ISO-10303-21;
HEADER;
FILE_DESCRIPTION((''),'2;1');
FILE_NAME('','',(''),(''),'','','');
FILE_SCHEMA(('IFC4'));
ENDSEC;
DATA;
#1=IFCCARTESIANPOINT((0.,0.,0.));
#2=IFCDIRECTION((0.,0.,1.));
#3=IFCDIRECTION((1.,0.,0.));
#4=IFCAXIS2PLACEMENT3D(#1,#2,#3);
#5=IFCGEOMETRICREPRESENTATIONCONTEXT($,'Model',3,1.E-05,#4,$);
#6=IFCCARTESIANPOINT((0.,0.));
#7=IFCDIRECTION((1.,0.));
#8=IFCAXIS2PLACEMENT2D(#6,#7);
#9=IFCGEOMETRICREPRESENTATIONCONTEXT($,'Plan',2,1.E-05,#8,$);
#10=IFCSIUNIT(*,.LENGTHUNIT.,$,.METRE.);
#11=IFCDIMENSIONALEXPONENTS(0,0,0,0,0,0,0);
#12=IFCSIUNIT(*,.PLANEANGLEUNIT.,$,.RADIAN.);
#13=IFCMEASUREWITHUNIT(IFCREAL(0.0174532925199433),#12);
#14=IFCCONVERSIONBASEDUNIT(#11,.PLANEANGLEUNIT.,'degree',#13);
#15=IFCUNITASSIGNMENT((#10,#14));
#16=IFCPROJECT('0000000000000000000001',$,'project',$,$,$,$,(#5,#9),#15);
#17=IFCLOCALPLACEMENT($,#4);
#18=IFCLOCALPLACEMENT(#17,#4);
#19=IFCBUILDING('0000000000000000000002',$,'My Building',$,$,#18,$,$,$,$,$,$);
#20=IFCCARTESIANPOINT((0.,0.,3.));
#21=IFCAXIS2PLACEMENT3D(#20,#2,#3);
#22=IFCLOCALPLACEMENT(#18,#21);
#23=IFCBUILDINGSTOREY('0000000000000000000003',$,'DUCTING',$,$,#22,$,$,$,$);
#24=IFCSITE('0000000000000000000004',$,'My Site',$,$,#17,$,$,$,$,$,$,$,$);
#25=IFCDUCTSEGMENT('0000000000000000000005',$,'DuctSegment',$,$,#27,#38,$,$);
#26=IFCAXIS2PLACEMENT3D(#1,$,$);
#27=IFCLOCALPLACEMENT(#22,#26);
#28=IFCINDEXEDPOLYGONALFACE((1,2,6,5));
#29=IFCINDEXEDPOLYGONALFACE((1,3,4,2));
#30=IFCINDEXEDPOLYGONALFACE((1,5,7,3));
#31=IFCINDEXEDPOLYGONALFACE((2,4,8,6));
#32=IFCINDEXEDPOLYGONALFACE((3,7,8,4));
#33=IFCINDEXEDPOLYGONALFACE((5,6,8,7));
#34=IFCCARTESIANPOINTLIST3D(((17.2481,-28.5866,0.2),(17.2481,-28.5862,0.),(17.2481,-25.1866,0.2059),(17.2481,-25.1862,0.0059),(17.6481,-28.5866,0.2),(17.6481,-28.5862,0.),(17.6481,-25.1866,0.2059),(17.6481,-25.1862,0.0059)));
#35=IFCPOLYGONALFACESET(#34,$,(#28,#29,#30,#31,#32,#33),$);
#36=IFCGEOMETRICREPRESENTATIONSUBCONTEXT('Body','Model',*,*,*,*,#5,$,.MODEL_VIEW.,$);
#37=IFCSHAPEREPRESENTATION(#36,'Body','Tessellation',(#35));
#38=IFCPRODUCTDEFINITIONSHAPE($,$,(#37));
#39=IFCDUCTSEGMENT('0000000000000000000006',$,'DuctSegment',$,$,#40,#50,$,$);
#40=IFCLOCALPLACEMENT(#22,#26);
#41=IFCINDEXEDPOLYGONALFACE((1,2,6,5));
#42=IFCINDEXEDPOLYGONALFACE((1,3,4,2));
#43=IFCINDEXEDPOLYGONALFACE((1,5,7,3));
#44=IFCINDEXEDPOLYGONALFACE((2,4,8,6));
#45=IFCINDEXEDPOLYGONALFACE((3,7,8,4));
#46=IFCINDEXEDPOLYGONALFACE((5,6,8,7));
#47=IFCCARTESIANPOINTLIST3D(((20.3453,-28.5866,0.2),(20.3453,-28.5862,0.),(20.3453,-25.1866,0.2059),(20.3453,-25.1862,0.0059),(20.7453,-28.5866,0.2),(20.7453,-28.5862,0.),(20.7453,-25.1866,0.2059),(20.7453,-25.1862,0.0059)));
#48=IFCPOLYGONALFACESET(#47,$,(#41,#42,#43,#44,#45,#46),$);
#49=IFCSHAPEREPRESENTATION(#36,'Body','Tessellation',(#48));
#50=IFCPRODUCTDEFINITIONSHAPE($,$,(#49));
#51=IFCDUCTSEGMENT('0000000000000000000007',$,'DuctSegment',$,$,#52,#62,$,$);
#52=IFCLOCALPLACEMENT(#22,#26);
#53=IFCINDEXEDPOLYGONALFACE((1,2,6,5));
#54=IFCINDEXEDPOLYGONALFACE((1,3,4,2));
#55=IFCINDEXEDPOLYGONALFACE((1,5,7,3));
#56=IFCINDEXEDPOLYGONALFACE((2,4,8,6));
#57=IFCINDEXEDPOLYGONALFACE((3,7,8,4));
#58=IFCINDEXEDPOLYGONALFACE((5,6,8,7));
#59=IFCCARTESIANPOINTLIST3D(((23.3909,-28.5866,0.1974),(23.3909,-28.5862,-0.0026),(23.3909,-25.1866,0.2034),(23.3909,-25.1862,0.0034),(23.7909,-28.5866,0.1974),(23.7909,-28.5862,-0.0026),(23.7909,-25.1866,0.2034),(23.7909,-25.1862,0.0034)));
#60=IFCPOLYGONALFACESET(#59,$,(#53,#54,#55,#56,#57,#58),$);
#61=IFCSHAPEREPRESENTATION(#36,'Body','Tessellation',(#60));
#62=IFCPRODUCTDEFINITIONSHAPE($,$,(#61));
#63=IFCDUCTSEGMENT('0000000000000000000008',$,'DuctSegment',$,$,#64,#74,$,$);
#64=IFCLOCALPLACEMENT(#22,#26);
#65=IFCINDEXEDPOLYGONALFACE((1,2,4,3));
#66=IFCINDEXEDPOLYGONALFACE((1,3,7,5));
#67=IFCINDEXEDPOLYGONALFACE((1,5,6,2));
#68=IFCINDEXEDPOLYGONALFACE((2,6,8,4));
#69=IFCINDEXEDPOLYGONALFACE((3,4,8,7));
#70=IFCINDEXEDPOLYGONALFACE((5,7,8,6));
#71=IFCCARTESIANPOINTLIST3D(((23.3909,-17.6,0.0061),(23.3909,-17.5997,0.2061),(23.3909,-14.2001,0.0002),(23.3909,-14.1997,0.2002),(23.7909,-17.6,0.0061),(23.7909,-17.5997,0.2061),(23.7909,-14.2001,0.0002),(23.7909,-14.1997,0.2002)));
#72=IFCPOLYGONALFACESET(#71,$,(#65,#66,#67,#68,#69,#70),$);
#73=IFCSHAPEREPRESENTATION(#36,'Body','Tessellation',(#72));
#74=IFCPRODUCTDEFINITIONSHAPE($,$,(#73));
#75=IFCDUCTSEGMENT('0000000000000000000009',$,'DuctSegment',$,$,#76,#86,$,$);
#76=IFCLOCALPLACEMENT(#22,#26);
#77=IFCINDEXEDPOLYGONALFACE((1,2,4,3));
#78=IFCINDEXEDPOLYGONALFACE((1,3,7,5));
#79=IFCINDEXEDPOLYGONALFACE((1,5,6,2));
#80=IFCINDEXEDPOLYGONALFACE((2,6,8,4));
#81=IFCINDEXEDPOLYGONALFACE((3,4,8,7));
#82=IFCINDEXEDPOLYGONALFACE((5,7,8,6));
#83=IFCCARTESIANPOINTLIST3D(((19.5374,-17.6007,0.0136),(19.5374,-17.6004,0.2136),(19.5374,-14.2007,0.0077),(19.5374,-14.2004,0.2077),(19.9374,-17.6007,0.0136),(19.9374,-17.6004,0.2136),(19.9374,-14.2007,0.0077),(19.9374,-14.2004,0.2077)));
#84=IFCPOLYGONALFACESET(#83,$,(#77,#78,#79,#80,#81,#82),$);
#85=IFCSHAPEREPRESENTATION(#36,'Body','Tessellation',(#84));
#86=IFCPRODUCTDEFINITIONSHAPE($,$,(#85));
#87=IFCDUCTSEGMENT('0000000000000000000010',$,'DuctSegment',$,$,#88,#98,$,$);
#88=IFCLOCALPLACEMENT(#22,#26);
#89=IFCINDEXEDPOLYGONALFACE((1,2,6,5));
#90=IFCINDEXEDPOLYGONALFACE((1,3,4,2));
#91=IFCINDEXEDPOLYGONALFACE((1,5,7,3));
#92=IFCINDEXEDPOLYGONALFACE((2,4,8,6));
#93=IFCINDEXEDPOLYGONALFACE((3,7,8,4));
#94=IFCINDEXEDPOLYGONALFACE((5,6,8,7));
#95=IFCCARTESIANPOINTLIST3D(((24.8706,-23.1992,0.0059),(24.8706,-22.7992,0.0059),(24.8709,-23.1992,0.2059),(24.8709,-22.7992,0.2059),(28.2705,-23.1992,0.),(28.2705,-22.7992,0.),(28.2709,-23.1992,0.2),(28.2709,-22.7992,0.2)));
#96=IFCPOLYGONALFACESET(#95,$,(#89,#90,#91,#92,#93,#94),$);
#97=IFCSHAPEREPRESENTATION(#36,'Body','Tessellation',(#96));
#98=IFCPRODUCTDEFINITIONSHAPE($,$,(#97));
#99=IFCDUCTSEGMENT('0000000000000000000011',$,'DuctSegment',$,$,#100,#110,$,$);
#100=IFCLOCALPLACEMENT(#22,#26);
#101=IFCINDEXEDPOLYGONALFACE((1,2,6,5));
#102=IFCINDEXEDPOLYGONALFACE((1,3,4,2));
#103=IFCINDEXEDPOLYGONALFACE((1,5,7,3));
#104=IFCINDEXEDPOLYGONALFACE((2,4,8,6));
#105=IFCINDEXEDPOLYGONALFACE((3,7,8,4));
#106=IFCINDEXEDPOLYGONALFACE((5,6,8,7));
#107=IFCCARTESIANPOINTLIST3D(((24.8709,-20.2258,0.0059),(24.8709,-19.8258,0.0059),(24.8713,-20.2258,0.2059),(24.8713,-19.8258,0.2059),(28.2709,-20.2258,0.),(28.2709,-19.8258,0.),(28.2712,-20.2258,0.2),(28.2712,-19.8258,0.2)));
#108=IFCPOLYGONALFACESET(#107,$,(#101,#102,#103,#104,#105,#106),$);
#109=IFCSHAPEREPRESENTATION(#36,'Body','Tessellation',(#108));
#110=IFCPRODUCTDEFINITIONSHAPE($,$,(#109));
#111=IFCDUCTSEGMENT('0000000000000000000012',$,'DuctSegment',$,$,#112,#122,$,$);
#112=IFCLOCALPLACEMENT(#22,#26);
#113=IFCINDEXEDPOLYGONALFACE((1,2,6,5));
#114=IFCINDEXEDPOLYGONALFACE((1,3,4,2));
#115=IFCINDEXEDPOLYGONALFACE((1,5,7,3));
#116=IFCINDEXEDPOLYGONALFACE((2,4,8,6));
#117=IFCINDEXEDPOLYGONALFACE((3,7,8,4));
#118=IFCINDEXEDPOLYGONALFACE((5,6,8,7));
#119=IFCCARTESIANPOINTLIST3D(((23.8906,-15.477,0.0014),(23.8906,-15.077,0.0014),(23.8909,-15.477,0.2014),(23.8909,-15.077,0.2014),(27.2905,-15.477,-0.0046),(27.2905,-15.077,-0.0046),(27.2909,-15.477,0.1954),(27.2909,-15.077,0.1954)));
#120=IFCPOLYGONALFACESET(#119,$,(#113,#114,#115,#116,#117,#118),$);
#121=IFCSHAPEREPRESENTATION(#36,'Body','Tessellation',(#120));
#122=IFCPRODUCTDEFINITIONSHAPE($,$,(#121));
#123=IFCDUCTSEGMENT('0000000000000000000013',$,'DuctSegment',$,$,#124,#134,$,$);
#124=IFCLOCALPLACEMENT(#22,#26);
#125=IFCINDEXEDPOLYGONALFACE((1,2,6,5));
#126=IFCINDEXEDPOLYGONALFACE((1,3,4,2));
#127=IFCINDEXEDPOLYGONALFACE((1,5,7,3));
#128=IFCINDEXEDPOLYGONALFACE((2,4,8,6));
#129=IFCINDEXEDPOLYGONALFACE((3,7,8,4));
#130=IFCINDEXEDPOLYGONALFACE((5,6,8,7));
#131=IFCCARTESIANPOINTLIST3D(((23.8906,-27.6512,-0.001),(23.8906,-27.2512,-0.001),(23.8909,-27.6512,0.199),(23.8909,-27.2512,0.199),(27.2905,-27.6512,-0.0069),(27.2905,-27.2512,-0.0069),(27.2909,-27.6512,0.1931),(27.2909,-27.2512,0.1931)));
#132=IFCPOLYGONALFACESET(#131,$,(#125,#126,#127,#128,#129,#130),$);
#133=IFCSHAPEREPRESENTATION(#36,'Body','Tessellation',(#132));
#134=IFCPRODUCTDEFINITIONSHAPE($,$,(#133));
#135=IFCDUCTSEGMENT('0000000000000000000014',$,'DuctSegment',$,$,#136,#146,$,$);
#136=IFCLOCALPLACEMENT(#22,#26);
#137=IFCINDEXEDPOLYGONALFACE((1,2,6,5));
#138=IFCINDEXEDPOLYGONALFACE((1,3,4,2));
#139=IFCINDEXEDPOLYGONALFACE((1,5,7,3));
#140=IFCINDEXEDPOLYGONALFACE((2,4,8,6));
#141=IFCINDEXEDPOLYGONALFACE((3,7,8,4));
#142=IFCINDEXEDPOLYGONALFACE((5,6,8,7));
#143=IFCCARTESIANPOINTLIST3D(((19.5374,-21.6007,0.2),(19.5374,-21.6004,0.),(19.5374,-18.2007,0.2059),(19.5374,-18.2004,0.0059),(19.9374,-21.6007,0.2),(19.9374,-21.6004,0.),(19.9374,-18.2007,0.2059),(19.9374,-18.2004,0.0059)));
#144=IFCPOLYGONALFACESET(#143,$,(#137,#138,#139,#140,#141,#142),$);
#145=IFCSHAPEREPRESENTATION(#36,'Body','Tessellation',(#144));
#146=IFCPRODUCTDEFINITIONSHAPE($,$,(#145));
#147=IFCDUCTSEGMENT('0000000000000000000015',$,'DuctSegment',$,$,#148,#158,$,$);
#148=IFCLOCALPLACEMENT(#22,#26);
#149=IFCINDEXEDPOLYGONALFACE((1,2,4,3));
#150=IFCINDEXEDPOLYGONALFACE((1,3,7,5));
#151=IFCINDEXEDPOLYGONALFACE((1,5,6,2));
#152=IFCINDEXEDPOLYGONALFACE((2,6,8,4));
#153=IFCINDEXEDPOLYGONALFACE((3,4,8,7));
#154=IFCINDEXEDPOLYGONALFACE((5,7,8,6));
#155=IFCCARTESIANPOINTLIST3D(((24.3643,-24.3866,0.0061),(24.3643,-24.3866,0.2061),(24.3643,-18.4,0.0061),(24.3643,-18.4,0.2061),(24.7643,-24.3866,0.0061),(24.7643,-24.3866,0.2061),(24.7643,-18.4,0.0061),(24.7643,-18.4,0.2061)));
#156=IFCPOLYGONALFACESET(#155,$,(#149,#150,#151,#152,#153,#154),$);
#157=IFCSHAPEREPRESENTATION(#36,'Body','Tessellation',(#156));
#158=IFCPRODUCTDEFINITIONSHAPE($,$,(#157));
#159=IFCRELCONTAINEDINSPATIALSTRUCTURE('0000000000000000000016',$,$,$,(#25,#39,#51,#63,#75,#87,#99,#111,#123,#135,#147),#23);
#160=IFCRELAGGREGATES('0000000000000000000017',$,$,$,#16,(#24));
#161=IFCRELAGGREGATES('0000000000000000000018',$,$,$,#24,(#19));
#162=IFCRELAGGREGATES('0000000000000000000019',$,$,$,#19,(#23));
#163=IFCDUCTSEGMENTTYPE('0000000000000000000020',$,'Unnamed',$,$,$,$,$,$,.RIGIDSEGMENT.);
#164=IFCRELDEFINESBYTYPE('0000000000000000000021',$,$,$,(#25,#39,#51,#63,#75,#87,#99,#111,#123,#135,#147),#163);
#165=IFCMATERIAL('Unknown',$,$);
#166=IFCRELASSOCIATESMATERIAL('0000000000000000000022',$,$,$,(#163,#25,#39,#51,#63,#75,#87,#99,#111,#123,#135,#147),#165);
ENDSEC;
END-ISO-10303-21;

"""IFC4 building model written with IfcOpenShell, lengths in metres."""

from ifc_helpers import new_model, entity, si_unit, converted_unit, frame, origin_with_axes, origin_2d_with_axis, place, context, subcontext, project, spatial, rectangle, extrude, material, material_profile, profile_set, profile_usage, type_object, element, save


model = new_model("IFC4")

# Units and contexts
model_context = context("Model", 3, precision=1e-05, world=origin_with_axes())
plan_context = context("Plan", 2, precision=1e-05, world=origin_2d_with_axis())
body_context = subcontext(model_context, "Body", "Model", "MODEL_VIEW")
ifc_project = project(units=[si_unit("LENGTHUNIT", "METRE"), converted_unit("PLANEANGLEUNIT", "degree", entity("IfcReal", 0.0174532925199433), si_unit("PLANEANGLEUNIT", "RADIAN"), dimensions=[0, 0, 0, 0, 0, 0, 0])], contexts=[model_context, plan_context])

# Site, building, storey
site_placement = place(None, origin_with_axes())
site = spatial("IfcSite", under=ifc_project, at=site_placement, Name="My Site")
building_placement = place(site_placement, origin_with_axes())
building = spatial("IfcBuilding", under=site, at=building_placement, Name="My Building")
storey_placement = place(building_placement, frame((0.0, 0.0, 3.0), z_axis=(0.0, 0.0, 1.0), x_axis=(1.0, 0.0, 0.0)))
storey = spatial("IfcBuildingStorey", under=building, at=storey_placement, Name="DUCTING")

# Duct segments
ifc_material = material(Name="Unknown")
ifc_material_profile_1 = material_profile(ifc_material, rectangle(XDim=0.4, YDim=0.2))
ifc_profile_set_1 = profile_set([ifc_material_profile_1])
ifc_profile_usage_1 = profile_usage(ifc_profile_set_1, cardinal=5)
duct_segment_type = type_object("IfcDuctSegmentType", Name="Unnamed", PredefinedType="RIGIDSEGMENT", material=ifc_profile_set_1)
duct_segment_1_placement = place(storey_placement, frame((17.4481, -25.1864, 0.1059), z_axis=(0.0, -0.999998, -0.001745), x_axis=(1.0, 0.0, 0.0)))
element("IfcDuctSegment", 1, at=duct_segment_1_placement, inside=storey, type_object=duct_segment_type, material=ifc_profile_usage_1, Name="DuctSegment", context=body_context, shape_type="SweptSolid", body=[
    extrude(rectangle(XDim=0.4, YDim=0.2), origin_with_axes(), (0.0, 0.0, 1.0), 3.4),
])
ifc_profile_usage_2 = profile_usage(ifc_profile_set_1, cardinal=5)
duct_segment_2_placement = place(storey_placement, frame((20.5453, -25.1864, 0.1059), z_axis=(0.0, -0.999998, -0.001745), x_axis=(1.0, 0.0, 0.0)))
element("IfcDuctSegment", 2, at=duct_segment_2_placement, inside=storey, type_object=duct_segment_type, material=ifc_profile_usage_2, Name="DuctSegment", context=body_context, shape_type="SweptSolid", body=[
    extrude(rectangle(XDim=0.4, YDim=0.2), origin_with_axes(), (0.0, 0.0, 1.0), 3.4),
])
ifc_profile_usage_3 = profile_usage(ifc_profile_set_1, cardinal=5)
duct_segment_3_placement = place(storey_placement, frame((23.5909, -25.1864, 0.1034), z_axis=(0.0, -0.999998, -0.001745), x_axis=(1.0, 0.0, 0.0)))
element("IfcDuctSegment", 3, at=duct_segment_3_placement, inside=storey, type_object=duct_segment_type, material=ifc_profile_usage_3, Name="DuctSegment", context=body_context, shape_type="SweptSolid", body=[
    extrude(rectangle(XDim=0.4, YDim=0.2), origin_with_axes(), (0.0, 0.0, 1.0), 3.4),
])
ifc_profile_usage_4 = profile_usage(ifc_profile_set_1, cardinal=5)
duct_segment_4_placement = place(storey_placement, frame((23.5909, -17.5999, 0.1061), z_axis=(0.0, 0.999998, -0.001745), x_axis=(-1.0, 0.0, 0.0)))
element("IfcDuctSegment", 4, at=duct_segment_4_placement, inside=storey, type_object=duct_segment_type, material=ifc_profile_usage_4, Name="DuctSegment", context=body_context, shape_type="SweptSolid", body=[
    extrude(rectangle(XDim=0.4, YDim=0.2), origin_with_axes(), (0.0, 0.0, 1.0), 3.4),
])
ifc_profile_usage_5 = profile_usage(ifc_profile_set_1, cardinal=5)
duct_segment_5_placement = place(storey_placement, frame((19.7374, -17.6006, 0.1136), z_axis=(0.0, 0.999998, -0.001745), x_axis=(-1.0, 0.0, 0.0)))
element("IfcDuctSegment", 5, at=duct_segment_5_placement, inside=storey, type_object=duct_segment_type, material=ifc_profile_usage_5, Name="DuctSegment", context=body_context, shape_type="SweptSolid", body=[
    extrude(rectangle(XDim=0.4, YDim=0.2), origin_with_axes(), (0.0, 0.0, 1.0), 3.4),
])
ifc_profile_usage_6 = profile_usage(ifc_profile_set_1, cardinal=5)
duct_segment_6_placement = place(storey_placement, frame((24.8707, -22.9992, 0.1059), z_axis=(0.999998, 0.0, -0.001745), x_axis=(0.0, 1.0, 0.0)))
element("IfcDuctSegment", 6, at=duct_segment_6_placement, inside=storey, type_object=duct_segment_type, material=ifc_profile_usage_6, Name="DuctSegment", context=body_context, shape_type="SweptSolid", body=[
    extrude(rectangle(XDim=0.4, YDim=0.2), origin_with_axes(), (0.0, 0.0, 1.0), 3.4),
])
ifc_profile_usage_7 = profile_usage(ifc_profile_set_1, cardinal=5)
duct_segment_7_placement = place(storey_placement, frame((24.8711, -20.0258, 0.1059), z_axis=(0.999998, 0.0, -0.001745), x_axis=(0.0, 1.0, 0.0)))
element("IfcDuctSegment", 7, at=duct_segment_7_placement, inside=storey, type_object=duct_segment_type, material=ifc_profile_usage_7, Name="DuctSegment", context=body_context, shape_type="SweptSolid", body=[
    extrude(rectangle(XDim=0.4, YDim=0.2), origin_with_axes(), (0.0, 0.0, 1.0), 3.4),
])
ifc_profile_usage_8 = profile_usage(ifc_profile_set_1, cardinal=5)
duct_segment_8_placement = place(storey_placement, frame((23.8907, -15.277, 0.1014), z_axis=(0.999998, 0.0, -0.001745), x_axis=(0.0, 1.0, 0.0)))
element("IfcDuctSegment", 8, at=duct_segment_8_placement, inside=storey, type_object=duct_segment_type, material=ifc_profile_usage_8, Name="DuctSegment", context=body_context, shape_type="SweptSolid", body=[
    extrude(rectangle(XDim=0.4, YDim=0.2), origin_with_axes(), (0.0, 0.0, 1.0), 3.4),
])
ifc_profile_usage_9 = profile_usage(ifc_profile_set_1, cardinal=5)
duct_segment_9_placement = place(storey_placement, frame((23.8907, -27.4512, 0.099), z_axis=(0.999998, 0.0, -0.001745), x_axis=(0.0, 1.0, 0.0)))
element("IfcDuctSegment", 9, at=duct_segment_9_placement, inside=storey, type_object=duct_segment_type, material=ifc_profile_usage_9, Name="DuctSegment", context=body_context, shape_type="SweptSolid", body=[
    extrude(rectangle(XDim=0.4, YDim=0.2), origin_with_axes(), (0.0, 0.0, 1.0), 3.4),
])
ifc_profile_usage_10 = profile_usage(ifc_profile_set_1, cardinal=5)
duct_segment_10_placement = place(storey_placement, frame((19.7374, -18.2006, 0.1059), z_axis=(0.0, -0.999998, -0.001745), x_axis=(1.0, 0.0, 0.0)))
element("IfcDuctSegment", 10, at=duct_segment_10_placement, inside=storey, type_object=duct_segment_type, material=ifc_profile_usage_10, Name="DuctSegment", context=body_context, shape_type="SweptSolid", body=[
    extrude(rectangle(XDim=0.4, YDim=0.2), origin_with_axes(), (0.0, 0.0, 1.0), 3.4),
])
ifc_profile_usage_11 = profile_usage(ifc_profile_set_1, cardinal=5)
duct_segment_11_placement = place(storey_placement, frame((24.5643, -18.4, 0.1061), z_axis=(0.0, -1.0, 0.0), x_axis=(1.0, 0.0, 0.0)))
element("IfcDuctSegment", 11, at=duct_segment_11_placement, inside=storey, type_object=duct_segment_type, material=ifc_profile_usage_11, Name="DuctSegment", context=body_context, shape_type="SweptSolid", body=[
    extrude(rectangle(XDim=0.4, YDim=0.2), origin_with_axes(), (0.0, 0.0, 1.0), 5.9866),
])

save(model, "model.ifc")
